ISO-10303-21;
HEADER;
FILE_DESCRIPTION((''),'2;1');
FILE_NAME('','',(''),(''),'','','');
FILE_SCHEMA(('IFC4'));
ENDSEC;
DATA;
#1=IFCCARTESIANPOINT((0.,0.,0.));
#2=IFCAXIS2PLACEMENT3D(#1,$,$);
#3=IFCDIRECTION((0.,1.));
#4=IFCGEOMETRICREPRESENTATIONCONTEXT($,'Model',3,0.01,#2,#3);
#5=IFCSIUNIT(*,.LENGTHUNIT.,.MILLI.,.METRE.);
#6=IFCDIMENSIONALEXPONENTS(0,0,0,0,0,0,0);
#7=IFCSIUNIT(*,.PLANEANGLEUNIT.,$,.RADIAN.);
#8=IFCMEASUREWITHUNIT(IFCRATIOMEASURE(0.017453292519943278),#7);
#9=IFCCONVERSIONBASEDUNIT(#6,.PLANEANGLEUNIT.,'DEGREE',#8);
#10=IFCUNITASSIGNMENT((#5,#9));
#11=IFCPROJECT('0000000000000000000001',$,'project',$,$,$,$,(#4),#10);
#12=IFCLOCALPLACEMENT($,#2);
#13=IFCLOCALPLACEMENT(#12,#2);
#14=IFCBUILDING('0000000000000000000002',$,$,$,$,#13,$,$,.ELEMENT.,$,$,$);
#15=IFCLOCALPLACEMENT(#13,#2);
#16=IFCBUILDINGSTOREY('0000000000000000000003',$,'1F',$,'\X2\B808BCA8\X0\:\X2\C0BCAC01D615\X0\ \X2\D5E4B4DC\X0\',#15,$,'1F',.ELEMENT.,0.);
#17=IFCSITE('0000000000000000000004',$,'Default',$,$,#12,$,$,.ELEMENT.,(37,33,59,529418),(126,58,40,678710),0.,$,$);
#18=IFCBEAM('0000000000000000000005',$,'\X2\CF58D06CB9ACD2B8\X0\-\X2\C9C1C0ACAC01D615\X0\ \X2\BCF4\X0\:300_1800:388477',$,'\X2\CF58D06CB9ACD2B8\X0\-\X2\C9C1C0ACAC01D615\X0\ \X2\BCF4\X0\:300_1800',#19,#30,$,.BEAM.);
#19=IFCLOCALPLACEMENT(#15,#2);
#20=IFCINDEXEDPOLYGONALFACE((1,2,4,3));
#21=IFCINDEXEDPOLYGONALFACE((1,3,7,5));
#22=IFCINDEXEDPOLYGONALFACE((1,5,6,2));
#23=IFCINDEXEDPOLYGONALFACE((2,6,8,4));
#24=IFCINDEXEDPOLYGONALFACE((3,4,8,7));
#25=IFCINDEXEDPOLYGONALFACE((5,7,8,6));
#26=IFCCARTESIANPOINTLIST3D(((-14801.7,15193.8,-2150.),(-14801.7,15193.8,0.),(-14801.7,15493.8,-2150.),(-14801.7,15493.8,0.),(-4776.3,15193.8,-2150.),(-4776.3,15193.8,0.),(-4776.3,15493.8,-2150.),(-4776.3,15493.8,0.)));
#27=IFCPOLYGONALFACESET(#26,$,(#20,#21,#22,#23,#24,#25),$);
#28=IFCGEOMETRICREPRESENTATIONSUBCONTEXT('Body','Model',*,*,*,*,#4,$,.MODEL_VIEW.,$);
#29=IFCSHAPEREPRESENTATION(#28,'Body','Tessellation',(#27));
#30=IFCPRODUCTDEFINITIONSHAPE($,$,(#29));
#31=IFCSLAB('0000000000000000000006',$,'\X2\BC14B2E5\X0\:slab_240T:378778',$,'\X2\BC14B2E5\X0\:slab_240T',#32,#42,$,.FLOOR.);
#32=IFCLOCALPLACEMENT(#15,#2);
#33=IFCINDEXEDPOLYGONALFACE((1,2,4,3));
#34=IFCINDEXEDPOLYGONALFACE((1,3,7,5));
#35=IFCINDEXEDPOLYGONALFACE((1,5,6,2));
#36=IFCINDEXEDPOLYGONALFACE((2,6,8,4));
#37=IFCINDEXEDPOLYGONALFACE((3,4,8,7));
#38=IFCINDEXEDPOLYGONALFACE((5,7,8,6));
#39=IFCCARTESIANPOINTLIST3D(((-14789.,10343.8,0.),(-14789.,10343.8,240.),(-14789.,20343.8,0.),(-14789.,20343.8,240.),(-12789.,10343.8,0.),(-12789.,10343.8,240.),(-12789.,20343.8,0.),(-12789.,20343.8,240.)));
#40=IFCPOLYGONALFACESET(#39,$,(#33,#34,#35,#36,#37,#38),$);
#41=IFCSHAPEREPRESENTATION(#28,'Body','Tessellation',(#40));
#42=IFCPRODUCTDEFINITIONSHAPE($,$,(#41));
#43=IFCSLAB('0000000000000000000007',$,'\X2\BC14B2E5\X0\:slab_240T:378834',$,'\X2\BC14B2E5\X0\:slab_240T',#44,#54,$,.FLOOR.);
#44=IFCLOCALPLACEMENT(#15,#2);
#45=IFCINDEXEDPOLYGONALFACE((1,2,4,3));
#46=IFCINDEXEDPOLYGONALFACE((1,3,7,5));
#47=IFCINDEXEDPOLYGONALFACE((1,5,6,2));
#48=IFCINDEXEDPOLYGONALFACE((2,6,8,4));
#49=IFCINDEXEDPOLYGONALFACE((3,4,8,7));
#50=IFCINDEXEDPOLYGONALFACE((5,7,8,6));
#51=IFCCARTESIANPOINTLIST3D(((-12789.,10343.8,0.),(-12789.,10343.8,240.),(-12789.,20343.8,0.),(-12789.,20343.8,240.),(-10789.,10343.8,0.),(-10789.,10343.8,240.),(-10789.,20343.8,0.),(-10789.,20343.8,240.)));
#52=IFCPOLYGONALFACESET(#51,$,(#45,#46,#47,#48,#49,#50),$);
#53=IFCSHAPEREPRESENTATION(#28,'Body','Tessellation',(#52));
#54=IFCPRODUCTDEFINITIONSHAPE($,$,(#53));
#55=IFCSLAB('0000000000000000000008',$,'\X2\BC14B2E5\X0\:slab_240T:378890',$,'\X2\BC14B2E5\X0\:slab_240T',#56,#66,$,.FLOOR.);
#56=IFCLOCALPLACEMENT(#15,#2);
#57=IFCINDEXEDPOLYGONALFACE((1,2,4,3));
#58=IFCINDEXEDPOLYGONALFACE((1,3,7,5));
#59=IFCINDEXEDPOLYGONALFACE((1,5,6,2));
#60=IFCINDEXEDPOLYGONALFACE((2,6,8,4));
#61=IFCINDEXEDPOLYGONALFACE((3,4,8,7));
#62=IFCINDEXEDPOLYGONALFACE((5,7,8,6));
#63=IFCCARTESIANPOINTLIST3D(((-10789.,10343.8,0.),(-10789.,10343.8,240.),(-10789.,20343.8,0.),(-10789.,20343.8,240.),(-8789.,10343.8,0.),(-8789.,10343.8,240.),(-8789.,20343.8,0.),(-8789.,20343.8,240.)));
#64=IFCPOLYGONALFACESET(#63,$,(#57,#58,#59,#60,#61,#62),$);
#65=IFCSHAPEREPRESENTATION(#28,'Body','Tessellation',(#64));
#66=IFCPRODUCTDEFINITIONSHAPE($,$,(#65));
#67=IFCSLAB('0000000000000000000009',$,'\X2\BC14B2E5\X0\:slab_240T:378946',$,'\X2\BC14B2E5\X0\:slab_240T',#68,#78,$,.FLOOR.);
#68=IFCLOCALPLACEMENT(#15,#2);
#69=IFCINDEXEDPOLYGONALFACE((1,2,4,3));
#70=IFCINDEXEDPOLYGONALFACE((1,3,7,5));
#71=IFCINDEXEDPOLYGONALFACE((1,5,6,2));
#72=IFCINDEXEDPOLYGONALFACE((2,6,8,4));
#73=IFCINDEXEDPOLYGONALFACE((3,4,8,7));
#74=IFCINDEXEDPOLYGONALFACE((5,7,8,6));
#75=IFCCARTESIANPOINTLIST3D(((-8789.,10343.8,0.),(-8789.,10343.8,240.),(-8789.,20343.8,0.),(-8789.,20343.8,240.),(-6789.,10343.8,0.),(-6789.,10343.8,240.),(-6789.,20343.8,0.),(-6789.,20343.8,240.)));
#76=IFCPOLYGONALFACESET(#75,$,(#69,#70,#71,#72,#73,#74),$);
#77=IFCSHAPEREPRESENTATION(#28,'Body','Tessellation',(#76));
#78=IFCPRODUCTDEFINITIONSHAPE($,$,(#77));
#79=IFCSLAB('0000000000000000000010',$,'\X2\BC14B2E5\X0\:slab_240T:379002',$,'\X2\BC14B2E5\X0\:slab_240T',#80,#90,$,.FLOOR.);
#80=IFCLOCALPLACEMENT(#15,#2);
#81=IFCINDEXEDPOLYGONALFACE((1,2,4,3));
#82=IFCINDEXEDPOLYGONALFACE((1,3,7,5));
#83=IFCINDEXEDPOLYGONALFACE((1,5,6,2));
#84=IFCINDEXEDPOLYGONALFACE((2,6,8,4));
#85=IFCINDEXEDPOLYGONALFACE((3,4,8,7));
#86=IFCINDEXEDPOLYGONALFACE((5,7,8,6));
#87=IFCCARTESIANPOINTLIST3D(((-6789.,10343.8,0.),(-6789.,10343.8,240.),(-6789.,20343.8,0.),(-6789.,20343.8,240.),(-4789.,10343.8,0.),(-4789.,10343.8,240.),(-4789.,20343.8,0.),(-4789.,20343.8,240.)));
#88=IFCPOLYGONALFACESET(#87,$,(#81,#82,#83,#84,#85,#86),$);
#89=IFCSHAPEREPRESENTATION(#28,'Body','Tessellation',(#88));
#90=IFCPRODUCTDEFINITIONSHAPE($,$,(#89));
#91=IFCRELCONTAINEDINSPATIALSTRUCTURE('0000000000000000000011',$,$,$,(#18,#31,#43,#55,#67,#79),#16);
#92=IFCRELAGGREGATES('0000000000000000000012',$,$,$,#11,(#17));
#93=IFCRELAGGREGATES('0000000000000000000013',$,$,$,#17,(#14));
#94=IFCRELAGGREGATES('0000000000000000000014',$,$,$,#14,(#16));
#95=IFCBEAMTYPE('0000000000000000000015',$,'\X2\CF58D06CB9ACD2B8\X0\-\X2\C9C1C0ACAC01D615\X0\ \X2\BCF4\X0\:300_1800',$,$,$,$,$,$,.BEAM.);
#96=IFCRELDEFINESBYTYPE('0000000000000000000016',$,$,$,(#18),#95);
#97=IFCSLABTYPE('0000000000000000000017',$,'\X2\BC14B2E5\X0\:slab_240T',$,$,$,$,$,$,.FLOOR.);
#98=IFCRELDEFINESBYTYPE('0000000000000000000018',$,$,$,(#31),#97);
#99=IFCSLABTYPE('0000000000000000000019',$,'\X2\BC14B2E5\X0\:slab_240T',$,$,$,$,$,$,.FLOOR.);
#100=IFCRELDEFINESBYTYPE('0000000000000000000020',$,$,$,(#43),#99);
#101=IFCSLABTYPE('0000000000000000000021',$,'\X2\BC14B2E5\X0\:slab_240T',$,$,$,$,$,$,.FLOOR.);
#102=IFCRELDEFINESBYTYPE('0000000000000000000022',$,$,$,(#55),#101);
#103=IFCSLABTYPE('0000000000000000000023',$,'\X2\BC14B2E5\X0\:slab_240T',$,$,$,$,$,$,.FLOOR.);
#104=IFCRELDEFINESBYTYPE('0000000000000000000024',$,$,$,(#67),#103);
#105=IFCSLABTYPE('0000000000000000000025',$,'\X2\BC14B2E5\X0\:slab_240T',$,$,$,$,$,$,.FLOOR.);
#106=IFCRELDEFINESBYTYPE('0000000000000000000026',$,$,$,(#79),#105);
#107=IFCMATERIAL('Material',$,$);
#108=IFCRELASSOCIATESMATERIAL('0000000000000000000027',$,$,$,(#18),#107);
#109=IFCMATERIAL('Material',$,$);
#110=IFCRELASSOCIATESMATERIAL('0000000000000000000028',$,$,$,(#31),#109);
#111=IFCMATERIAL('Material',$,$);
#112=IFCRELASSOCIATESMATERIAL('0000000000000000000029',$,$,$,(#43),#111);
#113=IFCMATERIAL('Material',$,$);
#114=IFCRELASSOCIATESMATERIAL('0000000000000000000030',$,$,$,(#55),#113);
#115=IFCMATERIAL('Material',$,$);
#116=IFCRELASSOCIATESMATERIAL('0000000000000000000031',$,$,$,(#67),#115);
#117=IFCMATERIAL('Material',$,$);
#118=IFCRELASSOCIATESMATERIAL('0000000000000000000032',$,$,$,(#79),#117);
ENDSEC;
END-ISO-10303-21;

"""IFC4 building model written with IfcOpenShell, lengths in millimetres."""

from ifc_helpers import new_model, entity, si_unit, converted_unit, direction, frame, origin, place, context, subcontext, project, spatial, indexed_curve, outline, extrude, source, transform, mapped, material, material_profile, profile_set, type_object, type_shapes, element, save


model = new_model("IFC4")

# Units and contexts
model_context = context("Model", 3, precision=0.01, world=origin(), true_north=direction((0.0, 1.0)))
body_context = subcontext(model_context, "Body", "Model", "MODEL_VIEW")
ifc_project = project(units=[si_unit("LENGTHUNIT", "METRE", prefix="MILLI"), converted_unit("PLANEANGLEUNIT", "DEGREE", entity("IfcRatioMeasure", 0.017453292519943278), si_unit("PLANEANGLEUNIT", "RADIAN"), dimensions=[0, 0, 0, 0, 0, 0, 0])], contexts=[model_context])

# Site, building, storey
site_placement = place(None, origin())
site = spatial("IfcSite", under=ifc_project, at=site_placement, Name="Default", CompositionType="ELEMENT", RefLatitude=(37, 33, 59, 529418), RefLongitude=(126, 58, 40, 678710), RefElevation=0.0)
building_placement = place(site_placement, origin())
building = spatial("IfcBuilding", under=site, at=building_placement, CompositionType="ELEMENT")
storey_placement = place(building_placement, origin())
storey = spatial("IfcBuildingStorey", under=building, at=storey_placement, Name="1F", ObjectType="레벨:삼각형 헤드", LongName="1F", CompositionType="ELEMENT", Elevation=0.0)

# Beam
ifc_material_1 = material(Name="Material")
ifc_material_profile_1 = material_profile(ifc_material_1, outline(indexed_curve([(-1075.0, -150.0), (1075.0, -150.0), (1075.0, 150.0), (-1075.0, 150.0), (-1075.0, -150.0)], self_intersect=False)))
ifc_profile_set_1 = profile_set([ifc_material_profile_1])
beam_type_1 = type_object("IfcBeamType", Name="콘크리트-직사각형 보:300_1800", PredefinedType="BEAM")
shared_shape_1 = source(origin(), body_context, "Body", "SweptSolid", [
    extrude(outline(indexed_curve([(-1075.0, -150.0), (1075.0, -150.0), (1075.0, 150.0), (-1075.0, 150.0), (-1075.0, -150.0)], self_intersect=False)), frame((-14801.7, 15343.8, -1075.0), z_axis=(1.0, 0.0, 0.0), x_axis=(0.0, 0.0, -1.0)), (0.0, 0.0, 1.0), 10025.4),
])
type_shapes(beam_type_1, [shared_shape_1])
beam_1_placement = place(storey_placement, origin())
element("IfcBeam", 1, at=beam_1_placement, inside=storey, type_object=beam_type_1, material=ifc_profile_set_1, Name="콘크리트-직사각형 보:300_1800:388477", ObjectType="콘크리트-직사각형 보:300_1800", PredefinedType="BEAM", context=body_context, shape_type="MappedRepresentation", body=[
    mapped(shared_shape_1, transform((0.0, 0.0, 0.0), scale=1.0)),
])

# Slabs
ifc_material_2 = material(Name="Material")
ifc_material_profile_2 = material_profile(ifc_material_2, outline(indexed_curve([(-5000.0, -1000.0), (5000.0, -1000.0), (5000.0, 1000.0), (-5000.0, 1000.0), (-5000.0, -1000.0)], self_intersect=False)))
ifc_profile_set_2 = profile_set([ifc_material_profile_2])
slab_type_1 = type_object("IfcSlabType", Name="바닥:slab_240T", PredefinedType="FLOOR")
slab_1_placement = place(storey_placement, origin())
element("IfcSlab", 2, at=slab_1_placement, inside=storey, type_object=slab_type_1, material=ifc_profile_set_2, Name="바닥:slab_240T:378778", ObjectType="바닥:slab_240T", PredefinedType="FLOOR", context=body_context, shape_type="SweptSolid", body=[
    extrude(outline(indexed_curve([(-5000.0, -1000.0), (5000.0, -1000.0), (5000.0, 1000.0), (-5000.0, 1000.0), (-5000.0, -1000.0)], self_intersect=False)), frame((-13789.0, 15343.8, 240.0), z_axis=(0.0, 0.0, -1.0), x_axis=(0.0, 1.0, 0.0)), (0.0, 0.0, 1.0), 240.0),
])
ifc_material_3 = material(Name="Material")
ifc_material_profile_3 = material_profile(ifc_material_3, outline(indexed_curve([(-5000.0, -1000.0), (5000.0, -1000.0), (5000.0, 1000.0), (-5000.0, 1000.0), (-5000.0, -1000.0)], self_intersect=False)))
ifc_profile_set_3 = profile_set([ifc_material_profile_3])
slab_type_2 = type_object("IfcSlabType", Name="바닥:slab_240T", PredefinedType="FLOOR")
slab_2_placement = place(storey_placement, origin())
element("IfcSlab", 3, at=slab_2_placement, inside=storey, type_object=slab_type_2, material=ifc_profile_set_3, Name="바닥:slab_240T:378834", ObjectType="바닥:slab_240T", PredefinedType="FLOOR", context=body_context, shape_type="SweptSolid", body=[
    extrude(outline(indexed_curve([(-5000.0, -1000.0), (5000.0, -1000.0), (5000.0, 1000.0), (-5000.0, 1000.0), (-5000.0, -1000.0)], self_intersect=False)), frame((-11789.0, 15343.8, 240.0), z_axis=(0.0, 0.0, -1.0), x_axis=(0.0, 1.0, 0.0)), (0.0, 0.0, 1.0), 240.0),
])
ifc_material_4 = material(Name="Material")
ifc_material_profile_4 = material_profile(ifc_material_4, outline(indexed_curve([(-5000.0, -1000.0), (5000.0, -1000.0), (5000.0, 1000.0), (-5000.0, 1000.0), (-5000.0, -1000.0)], self_intersect=False)))
ifc_profile_set_4 = profile_set([ifc_material_profile_4])
slab_type_3 = type_object("IfcSlabType", Name="바닥:slab_240T", PredefinedType="FLOOR")
slab_3_placement = place(storey_placement, origin())
element("IfcSlab", 4, at=slab_3_placement, inside=storey, type_object=slab_type_3, material=ifc_profile_set_4, Name="바닥:slab_240T:378890", ObjectType="바닥:slab_240T", PredefinedType="FLOOR", context=body_context, shape_type="SweptSolid", body=[
    extrude(outline(indexed_curve([(-5000.0, -1000.0), (5000.0, -1000.0), (5000.0, 1000.0), (-5000.0, 1000.0), (-5000.0, -1000.0)], self_intersect=False)), frame((-9789.0, 15343.8, 240.0), z_axis=(0.0, 0.0, -1.0), x_axis=(0.0, 1.0, 0.0)), (0.0, 0.0, 1.0), 240.0),
])
ifc_material_5 = material(Name="Material")
ifc_material_profile_5 = material_profile(ifc_material_5, outline(indexed_curve([(-5000.0, -1000.0), (5000.0, -1000.0), (5000.0, 1000.0), (-5000.0, 1000.0), (-5000.0, -1000.0)], self_intersect=False)))
ifc_profile_set_5 = profile_set([ifc_material_profile_5])
slab_type_4 = type_object("IfcSlabType", Name="바닥:slab_240T", PredefinedType="FLOOR")
slab_4_placement = place(storey_placement, origin())
element("IfcSlab", 5, at=slab_4_placement, inside=storey, type_object=slab_type_4, material=ifc_profile_set_5, Name="바닥:slab_240T:378946", ObjectType="바닥:slab_240T", PredefinedType="FLOOR", context=body_context, shape_type="SweptSolid", body=[
    extrude(outline(indexed_curve([(-5000.0, -1000.0), (5000.0, -1000.0), (5000.0, 1000.0), (-5000.0, 1000.0), (-5000.0, -1000.0)], self_intersect=False)), frame((-7789.0, 15343.8, 240.0), z_axis=(0.0, 0.0, -1.0), x_axis=(0.0, 1.0, 0.0)), (0.0, 0.0, 1.0), 240.0),
])
ifc_material_6 = material(Name="Material")
ifc_material_profile_6 = material_profile(ifc_material_6, outline(indexed_curve([(-5000.0, -1000.0), (5000.0, -1000.0), (5000.0, 1000.0), (-5000.0, 1000.0), (-5000.0, -1000.0)], self_intersect=False)))
ifc_profile_set_6 = profile_set([ifc_material_profile_6])
slab_type_5 = type_object("IfcSlabType", Name="바닥:slab_240T", PredefinedType="FLOOR")
slab_5_placement = place(storey_placement, origin())
element("IfcSlab", 6, at=slab_5_placement, inside=storey, type_object=slab_type_5, material=ifc_profile_set_6, Name="바닥:slab_240T:379002", ObjectType="바닥:slab_240T", PredefinedType="FLOOR", context=body_context, shape_type="SweptSolid", body=[
    extrude(outline(indexed_curve([(-5000.0, -1000.0), (5000.0, -1000.0), (5000.0, 1000.0), (-5000.0, 1000.0), (-5000.0, -1000.0)], self_intersect=False)), frame((-5789.0, 15343.8, 240.0), z_axis=(0.0, 0.0, -1.0), x_axis=(0.0, 1.0, 0.0)), (0.0, 0.0, 1.0), 240.0),
])

save(model, "model.ifc")
